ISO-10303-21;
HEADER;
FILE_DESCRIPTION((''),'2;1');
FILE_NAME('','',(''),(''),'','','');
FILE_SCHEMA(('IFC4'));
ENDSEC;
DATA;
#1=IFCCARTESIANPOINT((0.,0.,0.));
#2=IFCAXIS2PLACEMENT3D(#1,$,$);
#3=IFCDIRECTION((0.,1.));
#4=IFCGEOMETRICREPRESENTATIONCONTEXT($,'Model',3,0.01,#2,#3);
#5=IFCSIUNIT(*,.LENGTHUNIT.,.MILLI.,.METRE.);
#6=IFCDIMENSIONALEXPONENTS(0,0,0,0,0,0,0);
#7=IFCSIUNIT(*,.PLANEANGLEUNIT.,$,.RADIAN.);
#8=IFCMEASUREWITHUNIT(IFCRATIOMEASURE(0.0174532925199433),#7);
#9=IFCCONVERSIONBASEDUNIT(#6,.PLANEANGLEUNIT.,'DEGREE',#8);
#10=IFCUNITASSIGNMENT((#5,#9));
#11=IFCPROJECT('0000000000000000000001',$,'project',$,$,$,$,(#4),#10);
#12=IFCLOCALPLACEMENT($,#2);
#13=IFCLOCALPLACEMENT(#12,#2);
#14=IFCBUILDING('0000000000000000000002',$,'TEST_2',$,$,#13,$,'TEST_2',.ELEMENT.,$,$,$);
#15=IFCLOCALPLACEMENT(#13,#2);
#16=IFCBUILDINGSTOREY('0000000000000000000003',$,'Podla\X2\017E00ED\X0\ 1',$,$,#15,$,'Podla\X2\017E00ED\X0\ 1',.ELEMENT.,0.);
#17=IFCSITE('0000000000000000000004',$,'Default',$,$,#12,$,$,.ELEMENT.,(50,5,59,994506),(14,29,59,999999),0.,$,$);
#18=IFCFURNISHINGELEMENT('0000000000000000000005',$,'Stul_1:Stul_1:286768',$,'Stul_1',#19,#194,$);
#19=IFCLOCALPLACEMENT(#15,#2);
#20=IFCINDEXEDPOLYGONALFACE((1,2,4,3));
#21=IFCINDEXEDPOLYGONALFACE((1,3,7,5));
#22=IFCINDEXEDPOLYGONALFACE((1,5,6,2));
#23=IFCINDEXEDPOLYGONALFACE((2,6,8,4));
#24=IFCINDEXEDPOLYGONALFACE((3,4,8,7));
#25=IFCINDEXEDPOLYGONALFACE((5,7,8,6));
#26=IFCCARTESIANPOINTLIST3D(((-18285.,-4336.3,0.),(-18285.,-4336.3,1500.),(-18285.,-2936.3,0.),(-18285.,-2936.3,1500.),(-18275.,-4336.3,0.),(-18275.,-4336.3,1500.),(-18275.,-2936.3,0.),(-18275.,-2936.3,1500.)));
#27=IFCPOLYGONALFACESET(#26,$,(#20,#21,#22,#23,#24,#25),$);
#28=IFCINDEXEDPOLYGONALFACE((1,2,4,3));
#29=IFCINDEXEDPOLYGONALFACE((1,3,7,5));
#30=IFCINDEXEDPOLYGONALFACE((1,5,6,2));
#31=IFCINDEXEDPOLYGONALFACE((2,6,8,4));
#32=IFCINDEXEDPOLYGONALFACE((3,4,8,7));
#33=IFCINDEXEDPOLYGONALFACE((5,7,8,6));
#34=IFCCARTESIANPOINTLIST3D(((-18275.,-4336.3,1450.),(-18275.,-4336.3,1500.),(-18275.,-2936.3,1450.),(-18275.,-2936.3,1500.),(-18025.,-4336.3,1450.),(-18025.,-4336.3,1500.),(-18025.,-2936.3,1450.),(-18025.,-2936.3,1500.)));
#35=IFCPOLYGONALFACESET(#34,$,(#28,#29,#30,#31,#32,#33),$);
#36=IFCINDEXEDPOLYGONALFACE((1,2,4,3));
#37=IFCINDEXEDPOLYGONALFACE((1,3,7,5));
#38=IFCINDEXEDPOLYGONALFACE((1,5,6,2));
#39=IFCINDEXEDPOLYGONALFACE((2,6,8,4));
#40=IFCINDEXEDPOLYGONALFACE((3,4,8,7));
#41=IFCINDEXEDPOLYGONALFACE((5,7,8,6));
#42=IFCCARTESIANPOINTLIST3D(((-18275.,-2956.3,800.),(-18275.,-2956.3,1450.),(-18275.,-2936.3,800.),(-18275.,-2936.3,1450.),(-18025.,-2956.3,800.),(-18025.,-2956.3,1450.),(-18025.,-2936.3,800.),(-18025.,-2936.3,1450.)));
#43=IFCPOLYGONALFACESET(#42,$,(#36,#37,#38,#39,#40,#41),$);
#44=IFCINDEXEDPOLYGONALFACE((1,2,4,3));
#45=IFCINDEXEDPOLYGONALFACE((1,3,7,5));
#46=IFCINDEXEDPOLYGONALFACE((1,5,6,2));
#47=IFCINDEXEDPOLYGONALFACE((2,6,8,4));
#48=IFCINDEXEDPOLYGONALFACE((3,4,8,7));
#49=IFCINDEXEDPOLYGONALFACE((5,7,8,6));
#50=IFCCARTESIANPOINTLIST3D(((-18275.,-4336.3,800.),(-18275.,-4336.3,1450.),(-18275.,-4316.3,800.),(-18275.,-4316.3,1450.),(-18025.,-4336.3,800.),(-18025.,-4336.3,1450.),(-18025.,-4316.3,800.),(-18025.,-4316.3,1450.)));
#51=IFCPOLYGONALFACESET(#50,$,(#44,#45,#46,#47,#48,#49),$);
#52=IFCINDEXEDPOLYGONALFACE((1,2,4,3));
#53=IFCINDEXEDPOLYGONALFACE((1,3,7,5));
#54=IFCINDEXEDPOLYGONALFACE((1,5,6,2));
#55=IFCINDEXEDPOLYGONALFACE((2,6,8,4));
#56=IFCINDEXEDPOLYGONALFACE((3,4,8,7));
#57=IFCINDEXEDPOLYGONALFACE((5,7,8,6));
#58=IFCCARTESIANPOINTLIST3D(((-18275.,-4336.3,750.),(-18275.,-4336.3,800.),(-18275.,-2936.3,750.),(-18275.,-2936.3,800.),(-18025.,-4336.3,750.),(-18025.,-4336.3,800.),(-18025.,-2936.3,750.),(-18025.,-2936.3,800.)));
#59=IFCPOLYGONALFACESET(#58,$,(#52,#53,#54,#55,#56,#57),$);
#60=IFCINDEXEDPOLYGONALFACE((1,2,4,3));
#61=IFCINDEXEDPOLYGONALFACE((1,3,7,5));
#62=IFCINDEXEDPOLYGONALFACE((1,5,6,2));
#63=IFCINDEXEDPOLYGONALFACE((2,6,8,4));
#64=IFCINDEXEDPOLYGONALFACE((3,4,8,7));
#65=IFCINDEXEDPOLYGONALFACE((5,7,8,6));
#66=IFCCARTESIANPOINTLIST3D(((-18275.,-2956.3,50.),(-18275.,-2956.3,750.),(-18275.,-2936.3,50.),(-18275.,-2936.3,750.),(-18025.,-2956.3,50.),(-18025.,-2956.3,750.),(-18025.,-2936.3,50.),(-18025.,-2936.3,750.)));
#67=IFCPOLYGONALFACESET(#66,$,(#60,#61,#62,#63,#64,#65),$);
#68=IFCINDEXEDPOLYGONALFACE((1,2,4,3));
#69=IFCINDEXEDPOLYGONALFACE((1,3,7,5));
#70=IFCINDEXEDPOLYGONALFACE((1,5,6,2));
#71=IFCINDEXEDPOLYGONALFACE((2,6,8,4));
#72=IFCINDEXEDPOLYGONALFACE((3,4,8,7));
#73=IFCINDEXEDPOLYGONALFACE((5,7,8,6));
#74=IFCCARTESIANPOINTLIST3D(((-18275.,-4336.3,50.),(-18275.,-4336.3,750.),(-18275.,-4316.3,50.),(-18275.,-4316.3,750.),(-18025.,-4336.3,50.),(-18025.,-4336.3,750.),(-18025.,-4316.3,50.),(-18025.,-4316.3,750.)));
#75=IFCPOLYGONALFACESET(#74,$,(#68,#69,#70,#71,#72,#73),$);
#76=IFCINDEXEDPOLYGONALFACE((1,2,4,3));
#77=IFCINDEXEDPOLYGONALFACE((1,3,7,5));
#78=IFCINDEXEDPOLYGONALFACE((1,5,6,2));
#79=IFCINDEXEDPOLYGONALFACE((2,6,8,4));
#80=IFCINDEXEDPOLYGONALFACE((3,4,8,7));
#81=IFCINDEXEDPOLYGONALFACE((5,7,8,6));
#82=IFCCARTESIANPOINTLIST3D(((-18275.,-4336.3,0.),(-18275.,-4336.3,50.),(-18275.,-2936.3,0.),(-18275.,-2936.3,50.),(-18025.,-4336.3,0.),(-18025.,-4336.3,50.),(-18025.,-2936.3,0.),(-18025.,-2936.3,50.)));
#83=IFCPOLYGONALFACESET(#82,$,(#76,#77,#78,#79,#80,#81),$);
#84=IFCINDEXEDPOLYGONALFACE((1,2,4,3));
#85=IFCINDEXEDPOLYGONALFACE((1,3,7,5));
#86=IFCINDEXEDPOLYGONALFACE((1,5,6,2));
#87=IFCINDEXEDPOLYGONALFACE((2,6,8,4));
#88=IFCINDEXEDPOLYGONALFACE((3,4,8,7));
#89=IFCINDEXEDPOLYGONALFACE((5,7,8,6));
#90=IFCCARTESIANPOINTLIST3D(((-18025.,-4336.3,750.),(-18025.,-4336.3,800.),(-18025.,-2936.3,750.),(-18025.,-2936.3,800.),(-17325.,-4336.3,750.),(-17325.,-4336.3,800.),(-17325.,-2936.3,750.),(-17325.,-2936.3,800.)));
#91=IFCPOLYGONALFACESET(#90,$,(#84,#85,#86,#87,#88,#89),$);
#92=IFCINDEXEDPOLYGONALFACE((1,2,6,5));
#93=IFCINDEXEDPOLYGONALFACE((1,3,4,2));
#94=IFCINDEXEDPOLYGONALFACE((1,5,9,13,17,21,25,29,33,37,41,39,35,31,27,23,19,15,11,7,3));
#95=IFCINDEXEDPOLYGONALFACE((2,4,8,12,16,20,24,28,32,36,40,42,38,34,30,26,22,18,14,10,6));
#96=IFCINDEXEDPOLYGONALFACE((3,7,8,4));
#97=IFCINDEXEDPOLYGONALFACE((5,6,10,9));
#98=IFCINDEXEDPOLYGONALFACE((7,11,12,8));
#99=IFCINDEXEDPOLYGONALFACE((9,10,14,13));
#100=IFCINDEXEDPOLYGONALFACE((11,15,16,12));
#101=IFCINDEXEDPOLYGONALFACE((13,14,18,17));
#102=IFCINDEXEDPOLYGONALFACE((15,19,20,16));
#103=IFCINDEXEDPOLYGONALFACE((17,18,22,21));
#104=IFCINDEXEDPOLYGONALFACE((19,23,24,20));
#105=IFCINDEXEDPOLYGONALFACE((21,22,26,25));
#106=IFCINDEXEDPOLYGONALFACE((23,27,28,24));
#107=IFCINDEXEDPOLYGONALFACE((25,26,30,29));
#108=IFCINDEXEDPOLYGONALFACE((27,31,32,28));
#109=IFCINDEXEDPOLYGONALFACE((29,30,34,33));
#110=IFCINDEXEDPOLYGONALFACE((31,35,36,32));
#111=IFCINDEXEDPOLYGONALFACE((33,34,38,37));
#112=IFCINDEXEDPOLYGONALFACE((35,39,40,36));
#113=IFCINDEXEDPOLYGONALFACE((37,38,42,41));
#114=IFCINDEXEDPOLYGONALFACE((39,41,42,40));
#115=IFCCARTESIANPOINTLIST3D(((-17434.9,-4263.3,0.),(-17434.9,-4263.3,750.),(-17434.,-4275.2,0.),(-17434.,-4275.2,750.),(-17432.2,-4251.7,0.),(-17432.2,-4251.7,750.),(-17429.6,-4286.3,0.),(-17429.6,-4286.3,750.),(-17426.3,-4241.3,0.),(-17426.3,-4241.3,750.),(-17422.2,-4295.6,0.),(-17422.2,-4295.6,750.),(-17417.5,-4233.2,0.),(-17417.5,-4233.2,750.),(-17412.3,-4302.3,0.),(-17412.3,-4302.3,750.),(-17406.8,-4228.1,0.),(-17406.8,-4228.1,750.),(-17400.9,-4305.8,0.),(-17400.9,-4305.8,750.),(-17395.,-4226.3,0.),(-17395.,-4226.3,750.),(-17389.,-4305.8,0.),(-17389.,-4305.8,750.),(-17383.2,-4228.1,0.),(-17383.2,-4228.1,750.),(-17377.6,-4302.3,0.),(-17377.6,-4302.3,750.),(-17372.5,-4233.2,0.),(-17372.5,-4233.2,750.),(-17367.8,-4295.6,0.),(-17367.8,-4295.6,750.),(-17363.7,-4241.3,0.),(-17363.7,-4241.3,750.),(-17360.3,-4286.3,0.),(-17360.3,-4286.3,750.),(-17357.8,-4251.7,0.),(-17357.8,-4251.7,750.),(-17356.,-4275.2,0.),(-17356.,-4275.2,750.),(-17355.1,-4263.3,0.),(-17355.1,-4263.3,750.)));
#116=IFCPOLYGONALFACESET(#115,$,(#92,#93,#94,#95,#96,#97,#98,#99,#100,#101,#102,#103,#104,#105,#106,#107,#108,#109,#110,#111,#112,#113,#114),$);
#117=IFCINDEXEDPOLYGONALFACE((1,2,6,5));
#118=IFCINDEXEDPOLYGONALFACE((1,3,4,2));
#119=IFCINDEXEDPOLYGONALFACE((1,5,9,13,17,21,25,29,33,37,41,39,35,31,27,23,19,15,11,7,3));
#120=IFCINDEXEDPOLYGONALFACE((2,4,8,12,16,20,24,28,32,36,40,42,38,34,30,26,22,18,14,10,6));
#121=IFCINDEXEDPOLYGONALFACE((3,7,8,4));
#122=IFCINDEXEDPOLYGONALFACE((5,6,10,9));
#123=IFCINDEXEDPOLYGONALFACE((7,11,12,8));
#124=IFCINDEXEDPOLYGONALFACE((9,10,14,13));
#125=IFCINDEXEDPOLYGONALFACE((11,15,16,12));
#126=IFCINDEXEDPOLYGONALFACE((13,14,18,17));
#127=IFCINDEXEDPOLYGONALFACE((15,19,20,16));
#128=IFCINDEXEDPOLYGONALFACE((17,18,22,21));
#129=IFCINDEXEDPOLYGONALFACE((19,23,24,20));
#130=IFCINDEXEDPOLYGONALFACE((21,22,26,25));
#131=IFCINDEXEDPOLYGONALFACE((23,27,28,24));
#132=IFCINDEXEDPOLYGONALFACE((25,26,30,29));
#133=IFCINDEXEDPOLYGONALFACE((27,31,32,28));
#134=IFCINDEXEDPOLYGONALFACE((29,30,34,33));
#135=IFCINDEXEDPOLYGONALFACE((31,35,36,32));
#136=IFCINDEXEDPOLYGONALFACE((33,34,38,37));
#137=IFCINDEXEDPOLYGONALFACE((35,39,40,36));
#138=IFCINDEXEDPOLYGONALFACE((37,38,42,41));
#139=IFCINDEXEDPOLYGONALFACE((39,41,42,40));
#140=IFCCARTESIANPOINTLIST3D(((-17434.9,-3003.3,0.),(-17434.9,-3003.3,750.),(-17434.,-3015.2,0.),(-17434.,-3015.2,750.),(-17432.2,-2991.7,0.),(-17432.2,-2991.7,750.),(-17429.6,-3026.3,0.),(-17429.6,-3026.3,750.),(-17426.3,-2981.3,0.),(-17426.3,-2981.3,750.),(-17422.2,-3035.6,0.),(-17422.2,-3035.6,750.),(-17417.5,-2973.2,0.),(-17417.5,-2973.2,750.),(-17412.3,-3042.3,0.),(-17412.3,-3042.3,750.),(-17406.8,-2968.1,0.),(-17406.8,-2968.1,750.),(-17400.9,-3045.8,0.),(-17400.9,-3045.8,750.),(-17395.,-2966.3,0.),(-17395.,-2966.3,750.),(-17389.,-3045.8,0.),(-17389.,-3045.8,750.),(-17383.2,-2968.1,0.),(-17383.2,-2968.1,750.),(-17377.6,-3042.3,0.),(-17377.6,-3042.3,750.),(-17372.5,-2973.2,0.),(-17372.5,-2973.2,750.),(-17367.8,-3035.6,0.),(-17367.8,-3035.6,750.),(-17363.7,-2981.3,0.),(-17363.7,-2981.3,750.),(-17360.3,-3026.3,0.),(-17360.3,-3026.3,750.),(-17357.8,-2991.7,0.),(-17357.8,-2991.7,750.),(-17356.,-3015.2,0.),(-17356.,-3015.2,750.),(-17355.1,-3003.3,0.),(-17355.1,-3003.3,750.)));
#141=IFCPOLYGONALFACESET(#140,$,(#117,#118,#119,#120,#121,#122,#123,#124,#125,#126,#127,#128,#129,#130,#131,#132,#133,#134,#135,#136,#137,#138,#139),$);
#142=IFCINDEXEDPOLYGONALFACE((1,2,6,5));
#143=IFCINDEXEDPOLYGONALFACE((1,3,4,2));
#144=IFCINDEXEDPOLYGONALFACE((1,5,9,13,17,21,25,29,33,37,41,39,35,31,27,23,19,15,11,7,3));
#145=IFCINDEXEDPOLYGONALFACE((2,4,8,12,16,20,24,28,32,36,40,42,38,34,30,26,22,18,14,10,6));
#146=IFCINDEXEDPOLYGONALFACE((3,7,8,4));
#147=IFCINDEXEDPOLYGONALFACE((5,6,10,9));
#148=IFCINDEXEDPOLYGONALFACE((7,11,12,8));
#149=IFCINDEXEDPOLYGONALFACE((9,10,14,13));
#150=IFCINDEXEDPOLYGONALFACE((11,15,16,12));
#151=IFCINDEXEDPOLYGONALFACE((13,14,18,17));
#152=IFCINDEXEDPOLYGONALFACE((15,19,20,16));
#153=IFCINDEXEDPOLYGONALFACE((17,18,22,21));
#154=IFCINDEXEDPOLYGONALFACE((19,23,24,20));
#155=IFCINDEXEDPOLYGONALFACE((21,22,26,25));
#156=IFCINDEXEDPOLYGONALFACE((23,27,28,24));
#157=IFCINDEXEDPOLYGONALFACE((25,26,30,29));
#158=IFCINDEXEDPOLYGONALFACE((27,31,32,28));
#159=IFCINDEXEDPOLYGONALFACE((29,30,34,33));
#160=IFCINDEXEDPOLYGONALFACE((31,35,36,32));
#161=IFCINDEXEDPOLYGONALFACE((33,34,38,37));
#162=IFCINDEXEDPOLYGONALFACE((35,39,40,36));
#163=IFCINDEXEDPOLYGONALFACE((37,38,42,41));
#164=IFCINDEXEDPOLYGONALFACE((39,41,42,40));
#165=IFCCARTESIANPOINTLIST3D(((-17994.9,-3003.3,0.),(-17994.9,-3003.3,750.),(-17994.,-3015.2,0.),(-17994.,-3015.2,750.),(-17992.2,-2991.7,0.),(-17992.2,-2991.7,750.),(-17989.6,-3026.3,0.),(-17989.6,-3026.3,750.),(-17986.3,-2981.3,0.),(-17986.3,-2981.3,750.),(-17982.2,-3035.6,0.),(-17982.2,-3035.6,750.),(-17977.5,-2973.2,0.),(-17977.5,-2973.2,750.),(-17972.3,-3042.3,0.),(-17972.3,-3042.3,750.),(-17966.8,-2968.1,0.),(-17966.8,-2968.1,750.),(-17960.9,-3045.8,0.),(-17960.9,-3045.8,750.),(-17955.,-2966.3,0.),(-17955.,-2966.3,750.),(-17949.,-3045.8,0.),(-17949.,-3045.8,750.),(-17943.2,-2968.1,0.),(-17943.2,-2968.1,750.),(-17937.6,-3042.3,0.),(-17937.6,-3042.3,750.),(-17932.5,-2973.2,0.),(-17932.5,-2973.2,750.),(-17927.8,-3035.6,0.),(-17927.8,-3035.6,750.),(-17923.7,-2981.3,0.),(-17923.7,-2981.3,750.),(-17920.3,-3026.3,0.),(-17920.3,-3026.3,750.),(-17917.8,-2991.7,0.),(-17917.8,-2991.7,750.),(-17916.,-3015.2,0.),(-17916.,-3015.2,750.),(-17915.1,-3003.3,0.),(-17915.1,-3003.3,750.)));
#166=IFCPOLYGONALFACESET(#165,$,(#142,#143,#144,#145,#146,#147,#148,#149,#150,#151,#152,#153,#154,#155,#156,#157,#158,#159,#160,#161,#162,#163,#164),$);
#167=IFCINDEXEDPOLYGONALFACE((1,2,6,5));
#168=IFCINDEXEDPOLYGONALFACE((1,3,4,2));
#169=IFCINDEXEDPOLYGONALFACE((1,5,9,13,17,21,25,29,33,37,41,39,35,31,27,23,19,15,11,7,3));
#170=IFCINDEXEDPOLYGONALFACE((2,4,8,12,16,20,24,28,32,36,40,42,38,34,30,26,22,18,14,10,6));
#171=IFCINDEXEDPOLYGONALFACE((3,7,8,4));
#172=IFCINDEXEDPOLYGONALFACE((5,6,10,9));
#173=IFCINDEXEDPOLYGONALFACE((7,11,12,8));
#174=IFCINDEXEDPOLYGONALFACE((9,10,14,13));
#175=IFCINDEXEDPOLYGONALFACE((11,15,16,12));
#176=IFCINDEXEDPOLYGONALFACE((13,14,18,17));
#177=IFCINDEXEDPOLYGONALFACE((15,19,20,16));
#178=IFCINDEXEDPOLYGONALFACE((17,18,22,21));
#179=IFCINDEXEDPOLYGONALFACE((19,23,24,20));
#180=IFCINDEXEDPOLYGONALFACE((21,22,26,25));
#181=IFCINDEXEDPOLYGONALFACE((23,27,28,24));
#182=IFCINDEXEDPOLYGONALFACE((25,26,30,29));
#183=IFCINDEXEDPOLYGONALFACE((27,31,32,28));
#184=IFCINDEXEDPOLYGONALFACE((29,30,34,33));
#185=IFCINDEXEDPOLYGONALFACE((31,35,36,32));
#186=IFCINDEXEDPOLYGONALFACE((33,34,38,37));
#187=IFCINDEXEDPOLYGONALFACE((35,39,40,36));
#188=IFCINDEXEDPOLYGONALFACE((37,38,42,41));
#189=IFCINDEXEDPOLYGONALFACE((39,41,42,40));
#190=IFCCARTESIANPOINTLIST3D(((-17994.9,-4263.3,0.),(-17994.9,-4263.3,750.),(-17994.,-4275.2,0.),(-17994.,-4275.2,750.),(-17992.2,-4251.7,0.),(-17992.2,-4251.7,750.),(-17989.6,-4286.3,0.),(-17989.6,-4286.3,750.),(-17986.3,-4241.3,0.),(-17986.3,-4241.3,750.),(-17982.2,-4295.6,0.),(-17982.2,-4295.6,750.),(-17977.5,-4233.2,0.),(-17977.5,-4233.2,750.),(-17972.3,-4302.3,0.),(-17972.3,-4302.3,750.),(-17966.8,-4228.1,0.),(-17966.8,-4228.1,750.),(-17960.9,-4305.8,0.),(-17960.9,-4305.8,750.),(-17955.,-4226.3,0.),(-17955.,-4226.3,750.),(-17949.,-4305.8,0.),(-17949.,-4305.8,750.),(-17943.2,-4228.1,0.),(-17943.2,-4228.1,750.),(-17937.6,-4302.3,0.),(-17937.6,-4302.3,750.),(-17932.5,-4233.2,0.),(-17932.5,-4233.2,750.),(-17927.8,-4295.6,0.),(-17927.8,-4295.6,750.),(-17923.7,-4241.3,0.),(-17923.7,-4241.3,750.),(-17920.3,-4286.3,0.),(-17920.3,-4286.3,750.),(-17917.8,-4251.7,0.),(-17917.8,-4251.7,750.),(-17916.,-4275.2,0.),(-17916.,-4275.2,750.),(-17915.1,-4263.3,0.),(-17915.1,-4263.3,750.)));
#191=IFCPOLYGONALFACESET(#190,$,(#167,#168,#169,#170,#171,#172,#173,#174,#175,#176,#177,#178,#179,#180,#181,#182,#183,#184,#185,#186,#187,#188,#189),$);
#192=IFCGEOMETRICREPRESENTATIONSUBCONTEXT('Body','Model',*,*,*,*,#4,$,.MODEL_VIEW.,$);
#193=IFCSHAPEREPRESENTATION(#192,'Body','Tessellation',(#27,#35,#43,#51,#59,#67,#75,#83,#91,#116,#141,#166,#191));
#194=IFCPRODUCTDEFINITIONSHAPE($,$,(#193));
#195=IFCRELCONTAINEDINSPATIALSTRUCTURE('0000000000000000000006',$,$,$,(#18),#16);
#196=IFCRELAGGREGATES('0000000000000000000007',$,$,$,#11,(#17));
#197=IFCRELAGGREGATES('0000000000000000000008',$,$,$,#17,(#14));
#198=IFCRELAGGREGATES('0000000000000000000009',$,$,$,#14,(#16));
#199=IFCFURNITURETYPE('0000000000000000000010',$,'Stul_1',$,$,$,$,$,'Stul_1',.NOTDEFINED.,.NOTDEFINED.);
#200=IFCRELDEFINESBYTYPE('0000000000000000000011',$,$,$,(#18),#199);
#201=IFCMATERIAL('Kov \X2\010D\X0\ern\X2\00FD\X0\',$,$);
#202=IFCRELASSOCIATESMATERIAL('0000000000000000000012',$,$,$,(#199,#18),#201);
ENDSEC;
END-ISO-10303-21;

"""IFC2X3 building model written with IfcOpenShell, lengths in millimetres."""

from ifc_helpers import new_model, entity, si_unit, converted_unit, direction, frame, frame_2d, origin, origin_2d_with_axis, place, context, subcontext, project, spatial, rectangle, circle, extrude, source, transform, mapped, material, type_object, type_shapes, element, save


model = new_model("IFC2X3")

# Units and contexts
model_context = context("Model", 3, precision=0.01, world=origin(), true_north=direction((0.0, 1.0)))
body_context = subcontext(model_context, "Body", "Model", "MODEL_VIEW")
ifc_project = project(units=[si_unit("LENGTHUNIT", "METRE", prefix="MILLI"), converted_unit("PLANEANGLEUNIT", "DEGREE", entity("IfcRatioMeasure", 0.0174532925199433), si_unit("PLANEANGLEUNIT", "RADIAN"), dimensions=[0, 0, 0, 0, 0, 0, 0])], contexts=[model_context])

# Site, building, storey
site_placement = place(None, origin())
site = spatial("IfcSite", under=ifc_project, at=site_placement, Name="Default", CompositionType="ELEMENT", RefLatitude=(50, 5, 59, 994506), RefLongitude=(14, 29, 59, 999999), RefElevation=0.0)
building_placement = place(site_placement, origin())
building = spatial("IfcBuilding", under=site, at=building_placement, Name="TEST_2", LongName="TEST_2", CompositionType="ELEMENT")
storey_placement = place(building_placement, origin())
storey = spatial("IfcBuildingStorey", under=building, at=storey_placement, Name="Podlaží 1", LongName="Podlaží 1", CompositionType="ELEMENT", Elevation=0.0)

# Furnishing element
ifc_material_1 = material(Name="Kov černý")
furniture_type = type_object("IfcFurnitureType", Name="Stul_1", ElementType="Stul_1", material=ifc_material_1)
shared_shape_1 = source(origin(), body_context, "Body", "SweptSolid", [
    extrude(rectangle(XDim=1400.0, YDim=10.0, at=origin_2d_with_axis()), frame((0.0, 605.0, 0.0), z_axis=(0.0, 0.0, 1.0), x_axis=(-1.0, 0.0, 0.0)), (0.0, 0.0, 1.0), 1500.0),
    extrude(rectangle(XDim=1400.0, YDim=250.0, at=frame_2d((0.0, 0.0), x_axis=(1.0, 0.0))), frame((0.0, 475.0, 1450.0), z_axis=(0.0, 0.0, 1.0), x_axis=(-1.0, 0.0, 0.0)), (0.0, 0.0, 1.0), 50.0),
    extrude(rectangle(XDim=20.0, YDim=250.0, at=origin_2d_with_axis()), frame((690.0, 475.0, 800.0), z_axis=(0.0, 0.0, 1.0), x_axis=(-1.0, 0.0, 0.0)), (0.0, 0.0, 1.0), 650.0),
    extrude(rectangle(XDim=20.0, YDim=250.0, at=frame_2d((0.0, 0.0), x_axis=(1.0, 0.0))), frame((-690.0, 475.0, 800.0), z_axis=(0.0, 0.0, 1.0), x_axis=(-1.0, 0.0, 0.0)), (0.0, 0.0, 1.0), 650.0),
    extrude(rectangle(XDim=1400.0, YDim=250.0, at=origin_2d_with_axis()), frame((0.0, 475.0, 750.0), z_axis=(0.0, 0.0, 1.0), x_axis=(-1.0, 0.0, 0.0)), (0.0, 0.0, 1.0), 50.0),
    extrude(rectangle(XDim=20.0, YDim=250.0, at=origin_2d_with_axis()), frame((690.0, 475.0, 50.0), z_axis=(0.0, 0.0, 1.0), x_axis=(-1.0, 0.0, 0.0)), (0.0, 0.0, 1.0), 700.0),
    extrude(rectangle(XDim=20.0, YDim=250.0, at=frame_2d((0.0, 0.0), x_axis=(1.0, 0.0))), frame((-690.0, 475.0, 50.0), z_axis=(0.0, 0.0, 1.0), x_axis=(-1.0, 0.0, 0.0)), (0.0, 0.0, 1.0), 700.0),
    extrude(rectangle(XDim=1400.0, YDim=250.0, at=origin_2d_with_axis()), frame((0.0, 475.0, 0.0), z_axis=(0.0, 0.0, 1.0), x_axis=(-1.0, 0.0, 0.0)), (0.0, 0.0, 1.0), 50.0),
    extrude(rectangle(XDim=1400.0, YDim=700.0, at=origin_2d_with_axis()), frame((0.0, 0.0, 750.0), z_axis=(0.0, 0.0, 1.0), x_axis=(-1.0, 0.0, 0.0)), (0.0, 0.0, 1.0), 50.0),
    extrude(circle(Radius=40.0, at=frame_2d((0.0, 0.0), x_axis=(1.0, 0.0))), frame((-630.0, -280.0, 0.0)), (0.0, 0.0, 1.0), 750.0),
    extrude(circle(Radius=40.0, at=frame_2d((0.0, 0.0), x_axis=(1.0, 0.0))), frame((630.0, -280.0, 0.0)), (0.0, 0.0, 1.0), 750.0),
    extrude(circle(Radius=40.0, at=frame_2d((0.0, 0.0), x_axis=(1.0, 0.0))), frame((630.0, 280.0, 0.0)), (0.0, 0.0, 1.0), 750.0),
    extrude(circle(Radius=40.0, at=frame_2d((0.0, 0.0), x_axis=(1.0, 0.0))), frame((-630.0, 280.0, 0.0)), (0.0, 0.0, 1.0), 750.0),
])
type_shapes(furniture_type, [shared_shape_1])
for number, where, z_axis, x_axis, name in (
    (1, (-17675.0, -3636.3, 0.0), (0.0, 0.0, 1.0), (0.0, 1.0, 0.0), "Stul_1:Stul_1:286768"),
):
    element("IfcFurnishingElement", number, at=place(storey_placement, frame(where, z_axis=z_axis, x_axis=x_axis)), inside=storey, type_object=furniture_type, material=ifc_material_1, Name=name, ObjectType="Stul_1", context=body_context, shape_type="MappedRepresentation", body=[
        mapped(shared_shape_1, transform((0.0, 0.0, 0.0), scale=1.0)),
    ])

save(model, "model.ifc")
